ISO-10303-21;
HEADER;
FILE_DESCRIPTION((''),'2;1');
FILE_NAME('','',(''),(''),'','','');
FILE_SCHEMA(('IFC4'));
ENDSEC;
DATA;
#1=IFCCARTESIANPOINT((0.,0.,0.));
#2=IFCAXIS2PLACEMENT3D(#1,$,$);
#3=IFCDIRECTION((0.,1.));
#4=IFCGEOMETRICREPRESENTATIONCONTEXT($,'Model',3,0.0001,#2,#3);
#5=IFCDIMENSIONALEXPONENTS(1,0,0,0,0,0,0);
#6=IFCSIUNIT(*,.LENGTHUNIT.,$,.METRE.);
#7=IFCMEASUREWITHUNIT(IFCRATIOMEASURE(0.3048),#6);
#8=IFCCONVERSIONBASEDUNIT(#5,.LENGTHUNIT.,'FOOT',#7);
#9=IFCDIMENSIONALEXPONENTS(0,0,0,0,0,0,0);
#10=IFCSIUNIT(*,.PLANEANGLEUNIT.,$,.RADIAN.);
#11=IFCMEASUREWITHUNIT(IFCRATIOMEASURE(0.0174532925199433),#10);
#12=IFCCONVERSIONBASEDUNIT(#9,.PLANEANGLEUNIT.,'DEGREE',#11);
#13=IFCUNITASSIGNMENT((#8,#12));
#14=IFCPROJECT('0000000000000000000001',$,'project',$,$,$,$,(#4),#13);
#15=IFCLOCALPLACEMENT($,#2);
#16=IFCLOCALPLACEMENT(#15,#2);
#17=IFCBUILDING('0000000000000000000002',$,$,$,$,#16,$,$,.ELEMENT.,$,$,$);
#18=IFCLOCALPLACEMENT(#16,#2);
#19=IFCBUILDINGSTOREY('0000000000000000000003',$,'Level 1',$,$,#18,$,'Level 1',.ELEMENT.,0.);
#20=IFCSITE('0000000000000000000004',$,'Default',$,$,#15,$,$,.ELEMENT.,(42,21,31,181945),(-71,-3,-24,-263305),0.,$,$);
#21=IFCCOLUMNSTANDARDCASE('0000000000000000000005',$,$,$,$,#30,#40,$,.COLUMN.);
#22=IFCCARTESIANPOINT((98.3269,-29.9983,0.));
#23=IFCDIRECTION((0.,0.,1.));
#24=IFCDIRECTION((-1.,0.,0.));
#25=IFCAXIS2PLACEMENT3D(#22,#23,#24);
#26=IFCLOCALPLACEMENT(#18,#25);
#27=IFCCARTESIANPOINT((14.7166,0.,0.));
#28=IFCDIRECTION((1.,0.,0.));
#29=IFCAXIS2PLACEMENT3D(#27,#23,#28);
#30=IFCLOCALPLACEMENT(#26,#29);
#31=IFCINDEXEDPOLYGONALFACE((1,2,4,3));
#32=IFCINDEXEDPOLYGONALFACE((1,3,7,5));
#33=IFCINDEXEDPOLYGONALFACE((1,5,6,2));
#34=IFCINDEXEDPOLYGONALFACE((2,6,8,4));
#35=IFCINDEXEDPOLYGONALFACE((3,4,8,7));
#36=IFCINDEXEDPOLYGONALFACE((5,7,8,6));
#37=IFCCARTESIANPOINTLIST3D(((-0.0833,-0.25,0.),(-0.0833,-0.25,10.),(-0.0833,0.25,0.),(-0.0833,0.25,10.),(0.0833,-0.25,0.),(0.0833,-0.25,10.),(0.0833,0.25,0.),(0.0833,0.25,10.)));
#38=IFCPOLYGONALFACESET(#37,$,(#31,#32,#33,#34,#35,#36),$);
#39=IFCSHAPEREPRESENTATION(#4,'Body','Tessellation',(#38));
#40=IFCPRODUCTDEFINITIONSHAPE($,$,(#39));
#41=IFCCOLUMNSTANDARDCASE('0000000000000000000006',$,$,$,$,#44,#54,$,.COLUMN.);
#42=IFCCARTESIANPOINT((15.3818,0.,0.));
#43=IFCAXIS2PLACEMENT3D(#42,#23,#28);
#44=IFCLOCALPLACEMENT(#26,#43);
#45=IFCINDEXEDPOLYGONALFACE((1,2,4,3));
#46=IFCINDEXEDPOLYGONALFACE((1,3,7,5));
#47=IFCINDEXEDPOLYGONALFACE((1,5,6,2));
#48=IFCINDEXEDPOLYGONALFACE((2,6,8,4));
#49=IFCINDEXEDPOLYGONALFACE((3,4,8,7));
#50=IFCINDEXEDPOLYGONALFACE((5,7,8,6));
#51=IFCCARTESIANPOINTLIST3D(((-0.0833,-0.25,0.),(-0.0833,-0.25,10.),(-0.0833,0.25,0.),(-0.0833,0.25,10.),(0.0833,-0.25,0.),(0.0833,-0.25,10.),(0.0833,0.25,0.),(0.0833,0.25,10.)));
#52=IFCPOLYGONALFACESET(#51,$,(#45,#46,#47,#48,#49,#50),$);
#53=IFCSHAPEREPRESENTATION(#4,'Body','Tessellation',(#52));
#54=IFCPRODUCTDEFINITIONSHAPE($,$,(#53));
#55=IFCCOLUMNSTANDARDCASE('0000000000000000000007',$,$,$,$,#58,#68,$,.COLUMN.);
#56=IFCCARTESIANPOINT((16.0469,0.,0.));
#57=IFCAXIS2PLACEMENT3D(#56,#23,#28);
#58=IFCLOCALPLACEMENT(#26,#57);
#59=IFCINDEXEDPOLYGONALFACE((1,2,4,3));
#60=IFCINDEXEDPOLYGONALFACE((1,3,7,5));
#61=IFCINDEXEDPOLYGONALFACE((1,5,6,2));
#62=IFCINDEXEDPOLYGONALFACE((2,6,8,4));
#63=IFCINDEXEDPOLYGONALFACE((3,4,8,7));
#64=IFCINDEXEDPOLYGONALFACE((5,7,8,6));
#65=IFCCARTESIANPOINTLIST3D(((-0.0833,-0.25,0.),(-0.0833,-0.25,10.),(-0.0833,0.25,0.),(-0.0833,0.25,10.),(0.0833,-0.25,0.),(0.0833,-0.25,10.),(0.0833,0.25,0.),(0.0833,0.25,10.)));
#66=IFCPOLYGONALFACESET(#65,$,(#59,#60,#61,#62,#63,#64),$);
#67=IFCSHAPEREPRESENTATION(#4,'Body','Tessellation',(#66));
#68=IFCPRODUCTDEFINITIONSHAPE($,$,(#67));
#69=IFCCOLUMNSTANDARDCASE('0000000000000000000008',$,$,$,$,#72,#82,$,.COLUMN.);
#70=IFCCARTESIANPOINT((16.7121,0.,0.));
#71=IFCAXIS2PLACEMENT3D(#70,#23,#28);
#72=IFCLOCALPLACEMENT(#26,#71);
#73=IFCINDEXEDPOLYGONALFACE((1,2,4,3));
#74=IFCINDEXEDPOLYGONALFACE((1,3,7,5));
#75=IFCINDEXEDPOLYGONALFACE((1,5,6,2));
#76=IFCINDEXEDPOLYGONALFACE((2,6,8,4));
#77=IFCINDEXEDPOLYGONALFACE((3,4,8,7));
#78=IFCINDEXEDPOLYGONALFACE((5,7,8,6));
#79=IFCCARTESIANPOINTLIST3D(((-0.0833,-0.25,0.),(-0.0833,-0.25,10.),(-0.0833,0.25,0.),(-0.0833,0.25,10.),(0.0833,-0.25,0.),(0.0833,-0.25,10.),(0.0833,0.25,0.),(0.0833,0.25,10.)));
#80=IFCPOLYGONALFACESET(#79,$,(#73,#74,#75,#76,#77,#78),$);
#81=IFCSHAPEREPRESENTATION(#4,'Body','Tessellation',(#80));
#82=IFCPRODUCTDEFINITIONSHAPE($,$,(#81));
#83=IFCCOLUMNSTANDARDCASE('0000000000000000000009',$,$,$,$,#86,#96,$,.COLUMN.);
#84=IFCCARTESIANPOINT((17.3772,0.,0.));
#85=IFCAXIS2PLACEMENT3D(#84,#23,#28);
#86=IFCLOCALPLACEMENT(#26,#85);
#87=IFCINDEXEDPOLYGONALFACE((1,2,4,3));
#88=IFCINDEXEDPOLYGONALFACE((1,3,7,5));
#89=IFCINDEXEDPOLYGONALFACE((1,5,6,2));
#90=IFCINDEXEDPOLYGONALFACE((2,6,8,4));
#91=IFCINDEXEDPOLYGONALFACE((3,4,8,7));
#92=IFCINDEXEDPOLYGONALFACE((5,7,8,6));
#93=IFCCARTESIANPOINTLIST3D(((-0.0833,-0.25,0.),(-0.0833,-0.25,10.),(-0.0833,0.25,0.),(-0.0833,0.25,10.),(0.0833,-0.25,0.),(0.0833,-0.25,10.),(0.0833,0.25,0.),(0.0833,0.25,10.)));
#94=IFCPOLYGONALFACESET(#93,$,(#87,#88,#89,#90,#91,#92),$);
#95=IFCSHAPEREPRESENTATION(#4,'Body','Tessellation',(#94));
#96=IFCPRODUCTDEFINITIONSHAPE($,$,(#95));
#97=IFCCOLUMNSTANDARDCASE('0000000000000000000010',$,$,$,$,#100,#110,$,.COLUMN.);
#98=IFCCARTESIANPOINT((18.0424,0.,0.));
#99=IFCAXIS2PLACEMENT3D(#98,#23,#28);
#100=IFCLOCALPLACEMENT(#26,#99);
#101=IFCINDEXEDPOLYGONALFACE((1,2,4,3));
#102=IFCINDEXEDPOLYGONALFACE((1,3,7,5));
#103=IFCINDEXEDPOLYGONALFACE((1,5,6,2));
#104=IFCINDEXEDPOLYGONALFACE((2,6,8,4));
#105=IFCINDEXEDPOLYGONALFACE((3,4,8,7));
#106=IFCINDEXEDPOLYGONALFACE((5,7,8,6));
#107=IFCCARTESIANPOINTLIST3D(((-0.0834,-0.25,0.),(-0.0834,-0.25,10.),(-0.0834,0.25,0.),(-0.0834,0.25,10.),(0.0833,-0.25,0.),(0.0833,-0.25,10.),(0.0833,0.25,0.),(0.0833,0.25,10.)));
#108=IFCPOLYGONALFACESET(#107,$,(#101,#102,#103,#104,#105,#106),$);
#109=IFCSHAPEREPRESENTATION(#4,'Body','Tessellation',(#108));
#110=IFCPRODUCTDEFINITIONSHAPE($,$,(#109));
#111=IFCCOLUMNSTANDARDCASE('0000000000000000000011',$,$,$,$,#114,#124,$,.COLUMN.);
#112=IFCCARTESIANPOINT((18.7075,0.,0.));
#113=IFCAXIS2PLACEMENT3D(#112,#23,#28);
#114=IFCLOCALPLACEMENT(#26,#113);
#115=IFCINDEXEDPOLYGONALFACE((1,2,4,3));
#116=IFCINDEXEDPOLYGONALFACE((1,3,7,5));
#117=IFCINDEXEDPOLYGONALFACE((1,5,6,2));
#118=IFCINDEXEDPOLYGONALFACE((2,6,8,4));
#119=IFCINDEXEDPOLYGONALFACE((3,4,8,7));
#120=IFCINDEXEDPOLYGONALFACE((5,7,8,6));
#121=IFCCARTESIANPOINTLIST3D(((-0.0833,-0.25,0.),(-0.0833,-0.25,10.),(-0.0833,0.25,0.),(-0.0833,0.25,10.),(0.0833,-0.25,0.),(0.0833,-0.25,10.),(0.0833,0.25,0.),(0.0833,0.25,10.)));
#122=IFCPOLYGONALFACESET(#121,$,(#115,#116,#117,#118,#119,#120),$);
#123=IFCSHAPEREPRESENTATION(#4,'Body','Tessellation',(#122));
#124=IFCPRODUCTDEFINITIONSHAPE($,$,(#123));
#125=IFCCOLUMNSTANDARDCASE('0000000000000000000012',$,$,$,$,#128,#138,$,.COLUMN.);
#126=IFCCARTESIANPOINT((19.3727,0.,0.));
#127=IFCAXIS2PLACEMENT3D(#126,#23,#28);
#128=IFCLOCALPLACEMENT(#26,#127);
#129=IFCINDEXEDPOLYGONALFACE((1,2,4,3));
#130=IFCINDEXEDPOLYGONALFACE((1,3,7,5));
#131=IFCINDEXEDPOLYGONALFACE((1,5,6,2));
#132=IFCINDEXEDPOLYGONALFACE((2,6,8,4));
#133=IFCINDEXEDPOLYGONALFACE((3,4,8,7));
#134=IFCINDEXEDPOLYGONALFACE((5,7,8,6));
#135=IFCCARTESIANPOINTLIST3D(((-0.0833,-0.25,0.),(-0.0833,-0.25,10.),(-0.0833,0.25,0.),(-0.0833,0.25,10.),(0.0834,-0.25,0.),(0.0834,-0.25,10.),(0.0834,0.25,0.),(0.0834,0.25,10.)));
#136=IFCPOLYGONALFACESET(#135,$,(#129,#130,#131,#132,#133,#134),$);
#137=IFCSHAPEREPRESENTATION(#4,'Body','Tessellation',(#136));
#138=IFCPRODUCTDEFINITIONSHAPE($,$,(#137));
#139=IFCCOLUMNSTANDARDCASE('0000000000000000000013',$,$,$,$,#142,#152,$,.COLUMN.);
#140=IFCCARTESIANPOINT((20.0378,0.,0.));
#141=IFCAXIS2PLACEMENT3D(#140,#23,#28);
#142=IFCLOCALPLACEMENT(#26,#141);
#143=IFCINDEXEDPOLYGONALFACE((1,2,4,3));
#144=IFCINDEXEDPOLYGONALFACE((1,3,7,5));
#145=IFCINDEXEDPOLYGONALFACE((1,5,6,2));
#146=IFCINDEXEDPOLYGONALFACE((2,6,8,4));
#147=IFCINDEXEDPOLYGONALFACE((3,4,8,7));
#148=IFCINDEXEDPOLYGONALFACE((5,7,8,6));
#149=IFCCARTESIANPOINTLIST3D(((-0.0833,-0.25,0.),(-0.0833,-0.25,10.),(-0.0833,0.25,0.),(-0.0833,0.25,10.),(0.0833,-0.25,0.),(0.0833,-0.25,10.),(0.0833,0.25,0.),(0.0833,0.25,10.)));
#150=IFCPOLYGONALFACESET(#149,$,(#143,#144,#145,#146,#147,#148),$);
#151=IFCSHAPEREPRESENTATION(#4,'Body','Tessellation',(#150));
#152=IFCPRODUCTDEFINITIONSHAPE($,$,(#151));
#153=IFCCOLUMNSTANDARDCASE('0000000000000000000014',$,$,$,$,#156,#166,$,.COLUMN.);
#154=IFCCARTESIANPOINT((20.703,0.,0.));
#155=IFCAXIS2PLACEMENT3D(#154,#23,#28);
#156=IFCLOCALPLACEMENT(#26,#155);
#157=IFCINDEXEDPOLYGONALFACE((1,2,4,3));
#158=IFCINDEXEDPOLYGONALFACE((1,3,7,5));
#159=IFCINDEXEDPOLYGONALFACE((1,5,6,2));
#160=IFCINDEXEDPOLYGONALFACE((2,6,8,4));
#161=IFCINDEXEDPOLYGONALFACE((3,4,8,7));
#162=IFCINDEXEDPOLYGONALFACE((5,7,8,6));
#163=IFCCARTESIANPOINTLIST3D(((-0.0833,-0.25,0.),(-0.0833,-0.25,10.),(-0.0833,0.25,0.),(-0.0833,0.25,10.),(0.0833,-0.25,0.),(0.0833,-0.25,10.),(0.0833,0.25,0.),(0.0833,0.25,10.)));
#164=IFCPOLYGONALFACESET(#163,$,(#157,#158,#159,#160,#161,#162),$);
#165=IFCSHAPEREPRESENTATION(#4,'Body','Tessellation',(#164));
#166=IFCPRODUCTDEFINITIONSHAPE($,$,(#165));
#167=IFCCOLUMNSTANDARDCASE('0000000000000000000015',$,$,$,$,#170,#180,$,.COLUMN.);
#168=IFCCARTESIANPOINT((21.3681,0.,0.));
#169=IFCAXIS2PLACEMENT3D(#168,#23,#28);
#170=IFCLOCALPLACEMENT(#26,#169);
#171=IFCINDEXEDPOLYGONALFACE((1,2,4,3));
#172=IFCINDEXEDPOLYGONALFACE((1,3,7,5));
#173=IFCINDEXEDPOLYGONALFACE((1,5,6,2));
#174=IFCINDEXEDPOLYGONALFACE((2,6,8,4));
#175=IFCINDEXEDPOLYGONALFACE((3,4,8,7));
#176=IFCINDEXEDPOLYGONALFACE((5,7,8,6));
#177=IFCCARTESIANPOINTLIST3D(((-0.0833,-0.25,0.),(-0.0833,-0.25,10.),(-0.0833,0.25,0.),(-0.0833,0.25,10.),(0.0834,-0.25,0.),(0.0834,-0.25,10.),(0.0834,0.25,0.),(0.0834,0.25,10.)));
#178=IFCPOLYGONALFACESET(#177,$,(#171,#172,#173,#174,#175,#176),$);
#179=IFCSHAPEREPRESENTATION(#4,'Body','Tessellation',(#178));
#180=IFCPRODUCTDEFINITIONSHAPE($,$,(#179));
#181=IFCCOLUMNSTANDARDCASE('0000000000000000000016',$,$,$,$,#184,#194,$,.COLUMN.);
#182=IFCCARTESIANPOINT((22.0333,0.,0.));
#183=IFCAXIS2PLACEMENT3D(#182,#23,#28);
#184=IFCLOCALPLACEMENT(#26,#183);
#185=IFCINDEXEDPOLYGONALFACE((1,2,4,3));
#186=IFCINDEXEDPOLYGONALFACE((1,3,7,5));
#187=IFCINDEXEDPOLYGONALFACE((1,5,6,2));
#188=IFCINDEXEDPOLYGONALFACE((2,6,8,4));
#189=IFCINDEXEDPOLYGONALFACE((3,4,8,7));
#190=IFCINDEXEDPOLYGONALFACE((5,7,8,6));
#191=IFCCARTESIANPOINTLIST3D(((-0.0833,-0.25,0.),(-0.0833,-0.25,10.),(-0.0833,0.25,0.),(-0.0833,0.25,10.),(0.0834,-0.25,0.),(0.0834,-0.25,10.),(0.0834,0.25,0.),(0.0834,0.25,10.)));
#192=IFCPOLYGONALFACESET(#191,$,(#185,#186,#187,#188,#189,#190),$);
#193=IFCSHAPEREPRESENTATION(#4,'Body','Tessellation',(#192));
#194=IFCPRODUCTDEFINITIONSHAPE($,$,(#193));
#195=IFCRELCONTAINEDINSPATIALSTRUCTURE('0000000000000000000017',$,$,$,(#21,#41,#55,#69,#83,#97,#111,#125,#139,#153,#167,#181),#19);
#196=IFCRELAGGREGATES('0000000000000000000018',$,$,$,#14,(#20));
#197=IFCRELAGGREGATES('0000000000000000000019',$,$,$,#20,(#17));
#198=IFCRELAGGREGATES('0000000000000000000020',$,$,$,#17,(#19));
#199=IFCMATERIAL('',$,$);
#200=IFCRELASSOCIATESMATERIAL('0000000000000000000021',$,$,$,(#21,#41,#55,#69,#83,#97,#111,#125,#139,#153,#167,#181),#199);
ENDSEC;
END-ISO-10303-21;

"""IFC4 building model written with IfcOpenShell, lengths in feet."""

from ifc_helpers import new_model, entity, si_unit, converted_unit, direction, frame, origin, place, context, project, spatial, rectangle, extrude, material, element, save


model = new_model("IFC4")

# Units and contexts
model_context = context("Model", 3, precision=0.0001, world=origin(), true_north=direction((0.0, 1.0)))
ifc_project = project(units=[converted_unit("LENGTHUNIT", "FOOT", entity("IfcRatioMeasure", 0.3048), si_unit("LENGTHUNIT", "METRE"), dimensions=[1, 0, 0, 0, 0, 0, 0]), converted_unit("PLANEANGLEUNIT", "DEGREE", entity("IfcRatioMeasure", 0.0174532925199433), si_unit("PLANEANGLEUNIT", "RADIAN"), dimensions=[0, 0, 0, 0, 0, 0, 0])], contexts=[model_context])

# Site, building, storey
site_placement = place(None, origin())
site = spatial("IfcSite", under=ifc_project, at=site_placement, Name="Default", CompositionType="ELEMENT", RefLatitude=(42, 21, 31, 181945), RefLongitude=(-71, -3, -24, -263305), RefElevation=0.0)
building_placement = place(site_placement, origin())
building = spatial("IfcBuilding", under=site, at=building_placement, CompositionType="ELEMENT")
storey_placement = place(building_placement, origin())
storey = spatial("IfcBuildingStorey", under=building, at=storey_placement, Name="Level 1", LongName="Level 1", CompositionType="ELEMENT", Elevation=0.0)

# Columns
ifc_material = material(Name="")
placement = place(storey_placement, frame((98.3269, -29.9983, 0.0), z_axis=(0.0, 0.0, 1.0), x_axis=(-1.0, 0.0, 0.0)))
for number, where, z_axis, x_axis in (
    (1, (14.7166, 0.0, 0.0), (0.0, 0.0, 1.0), (1.0, 0.0, 0.0)),
    (2, (15.3818, 0.0, 0.0), (0.0, 0.0, 1.0), (1.0, 0.0, 0.0)),
    (3, (16.0469, 0.0, 0.0), (0.0, 0.0, 1.0), (1.0, 0.0, 0.0)),
    (4, (16.7121, 0.0, 0.0), (0.0, 0.0, 1.0), (1.0, 0.0, 0.0)),
    (5, (17.3772, 0.0, 0.0), (0.0, 0.0, 1.0), (1.0, 0.0, 0.0)),
    (6, (18.0424, 0.0, 0.0), (0.0, 0.0, 1.0), (1.0, 0.0, 0.0)),
    (7, (18.7075, 0.0, 0.0), (0.0, 0.0, 1.0), (1.0, 0.0, 0.0)),
    (8, (19.3727, 0.0, 0.0), (0.0, 0.0, 1.0), (1.0, 0.0, 0.0)),
    (9, (20.0378, 0.0, 0.0), (0.0, 0.0, 1.0), (1.0, 0.0, 0.0)),
    (10, (20.703, 0.0, 0.0), (0.0, 0.0, 1.0), (1.0, 0.0, 0.0)),
    (11, (21.3681, 0.0, 0.0), (0.0, 0.0, 1.0), (1.0, 0.0, 0.0)),
    (12, (22.0333, 0.0, 0.0), (0.0, 0.0, 1.0), (1.0, 0.0, 0.0)),
):
    element("IfcColumnStandardCase", number, at=place(placement, frame(where, z_axis=z_axis, x_axis=x_axis)), inside=storey, material=ifc_material, PredefinedType="COLUMN", context=model_context, shape_type="SweptSolid", body=[
        extrude(rectangle(XDim=0.1667, YDim=0.5), origin(), (0.0, 0.0, 1.0), 10.0),
    ])

save(model, "model.ifc")
